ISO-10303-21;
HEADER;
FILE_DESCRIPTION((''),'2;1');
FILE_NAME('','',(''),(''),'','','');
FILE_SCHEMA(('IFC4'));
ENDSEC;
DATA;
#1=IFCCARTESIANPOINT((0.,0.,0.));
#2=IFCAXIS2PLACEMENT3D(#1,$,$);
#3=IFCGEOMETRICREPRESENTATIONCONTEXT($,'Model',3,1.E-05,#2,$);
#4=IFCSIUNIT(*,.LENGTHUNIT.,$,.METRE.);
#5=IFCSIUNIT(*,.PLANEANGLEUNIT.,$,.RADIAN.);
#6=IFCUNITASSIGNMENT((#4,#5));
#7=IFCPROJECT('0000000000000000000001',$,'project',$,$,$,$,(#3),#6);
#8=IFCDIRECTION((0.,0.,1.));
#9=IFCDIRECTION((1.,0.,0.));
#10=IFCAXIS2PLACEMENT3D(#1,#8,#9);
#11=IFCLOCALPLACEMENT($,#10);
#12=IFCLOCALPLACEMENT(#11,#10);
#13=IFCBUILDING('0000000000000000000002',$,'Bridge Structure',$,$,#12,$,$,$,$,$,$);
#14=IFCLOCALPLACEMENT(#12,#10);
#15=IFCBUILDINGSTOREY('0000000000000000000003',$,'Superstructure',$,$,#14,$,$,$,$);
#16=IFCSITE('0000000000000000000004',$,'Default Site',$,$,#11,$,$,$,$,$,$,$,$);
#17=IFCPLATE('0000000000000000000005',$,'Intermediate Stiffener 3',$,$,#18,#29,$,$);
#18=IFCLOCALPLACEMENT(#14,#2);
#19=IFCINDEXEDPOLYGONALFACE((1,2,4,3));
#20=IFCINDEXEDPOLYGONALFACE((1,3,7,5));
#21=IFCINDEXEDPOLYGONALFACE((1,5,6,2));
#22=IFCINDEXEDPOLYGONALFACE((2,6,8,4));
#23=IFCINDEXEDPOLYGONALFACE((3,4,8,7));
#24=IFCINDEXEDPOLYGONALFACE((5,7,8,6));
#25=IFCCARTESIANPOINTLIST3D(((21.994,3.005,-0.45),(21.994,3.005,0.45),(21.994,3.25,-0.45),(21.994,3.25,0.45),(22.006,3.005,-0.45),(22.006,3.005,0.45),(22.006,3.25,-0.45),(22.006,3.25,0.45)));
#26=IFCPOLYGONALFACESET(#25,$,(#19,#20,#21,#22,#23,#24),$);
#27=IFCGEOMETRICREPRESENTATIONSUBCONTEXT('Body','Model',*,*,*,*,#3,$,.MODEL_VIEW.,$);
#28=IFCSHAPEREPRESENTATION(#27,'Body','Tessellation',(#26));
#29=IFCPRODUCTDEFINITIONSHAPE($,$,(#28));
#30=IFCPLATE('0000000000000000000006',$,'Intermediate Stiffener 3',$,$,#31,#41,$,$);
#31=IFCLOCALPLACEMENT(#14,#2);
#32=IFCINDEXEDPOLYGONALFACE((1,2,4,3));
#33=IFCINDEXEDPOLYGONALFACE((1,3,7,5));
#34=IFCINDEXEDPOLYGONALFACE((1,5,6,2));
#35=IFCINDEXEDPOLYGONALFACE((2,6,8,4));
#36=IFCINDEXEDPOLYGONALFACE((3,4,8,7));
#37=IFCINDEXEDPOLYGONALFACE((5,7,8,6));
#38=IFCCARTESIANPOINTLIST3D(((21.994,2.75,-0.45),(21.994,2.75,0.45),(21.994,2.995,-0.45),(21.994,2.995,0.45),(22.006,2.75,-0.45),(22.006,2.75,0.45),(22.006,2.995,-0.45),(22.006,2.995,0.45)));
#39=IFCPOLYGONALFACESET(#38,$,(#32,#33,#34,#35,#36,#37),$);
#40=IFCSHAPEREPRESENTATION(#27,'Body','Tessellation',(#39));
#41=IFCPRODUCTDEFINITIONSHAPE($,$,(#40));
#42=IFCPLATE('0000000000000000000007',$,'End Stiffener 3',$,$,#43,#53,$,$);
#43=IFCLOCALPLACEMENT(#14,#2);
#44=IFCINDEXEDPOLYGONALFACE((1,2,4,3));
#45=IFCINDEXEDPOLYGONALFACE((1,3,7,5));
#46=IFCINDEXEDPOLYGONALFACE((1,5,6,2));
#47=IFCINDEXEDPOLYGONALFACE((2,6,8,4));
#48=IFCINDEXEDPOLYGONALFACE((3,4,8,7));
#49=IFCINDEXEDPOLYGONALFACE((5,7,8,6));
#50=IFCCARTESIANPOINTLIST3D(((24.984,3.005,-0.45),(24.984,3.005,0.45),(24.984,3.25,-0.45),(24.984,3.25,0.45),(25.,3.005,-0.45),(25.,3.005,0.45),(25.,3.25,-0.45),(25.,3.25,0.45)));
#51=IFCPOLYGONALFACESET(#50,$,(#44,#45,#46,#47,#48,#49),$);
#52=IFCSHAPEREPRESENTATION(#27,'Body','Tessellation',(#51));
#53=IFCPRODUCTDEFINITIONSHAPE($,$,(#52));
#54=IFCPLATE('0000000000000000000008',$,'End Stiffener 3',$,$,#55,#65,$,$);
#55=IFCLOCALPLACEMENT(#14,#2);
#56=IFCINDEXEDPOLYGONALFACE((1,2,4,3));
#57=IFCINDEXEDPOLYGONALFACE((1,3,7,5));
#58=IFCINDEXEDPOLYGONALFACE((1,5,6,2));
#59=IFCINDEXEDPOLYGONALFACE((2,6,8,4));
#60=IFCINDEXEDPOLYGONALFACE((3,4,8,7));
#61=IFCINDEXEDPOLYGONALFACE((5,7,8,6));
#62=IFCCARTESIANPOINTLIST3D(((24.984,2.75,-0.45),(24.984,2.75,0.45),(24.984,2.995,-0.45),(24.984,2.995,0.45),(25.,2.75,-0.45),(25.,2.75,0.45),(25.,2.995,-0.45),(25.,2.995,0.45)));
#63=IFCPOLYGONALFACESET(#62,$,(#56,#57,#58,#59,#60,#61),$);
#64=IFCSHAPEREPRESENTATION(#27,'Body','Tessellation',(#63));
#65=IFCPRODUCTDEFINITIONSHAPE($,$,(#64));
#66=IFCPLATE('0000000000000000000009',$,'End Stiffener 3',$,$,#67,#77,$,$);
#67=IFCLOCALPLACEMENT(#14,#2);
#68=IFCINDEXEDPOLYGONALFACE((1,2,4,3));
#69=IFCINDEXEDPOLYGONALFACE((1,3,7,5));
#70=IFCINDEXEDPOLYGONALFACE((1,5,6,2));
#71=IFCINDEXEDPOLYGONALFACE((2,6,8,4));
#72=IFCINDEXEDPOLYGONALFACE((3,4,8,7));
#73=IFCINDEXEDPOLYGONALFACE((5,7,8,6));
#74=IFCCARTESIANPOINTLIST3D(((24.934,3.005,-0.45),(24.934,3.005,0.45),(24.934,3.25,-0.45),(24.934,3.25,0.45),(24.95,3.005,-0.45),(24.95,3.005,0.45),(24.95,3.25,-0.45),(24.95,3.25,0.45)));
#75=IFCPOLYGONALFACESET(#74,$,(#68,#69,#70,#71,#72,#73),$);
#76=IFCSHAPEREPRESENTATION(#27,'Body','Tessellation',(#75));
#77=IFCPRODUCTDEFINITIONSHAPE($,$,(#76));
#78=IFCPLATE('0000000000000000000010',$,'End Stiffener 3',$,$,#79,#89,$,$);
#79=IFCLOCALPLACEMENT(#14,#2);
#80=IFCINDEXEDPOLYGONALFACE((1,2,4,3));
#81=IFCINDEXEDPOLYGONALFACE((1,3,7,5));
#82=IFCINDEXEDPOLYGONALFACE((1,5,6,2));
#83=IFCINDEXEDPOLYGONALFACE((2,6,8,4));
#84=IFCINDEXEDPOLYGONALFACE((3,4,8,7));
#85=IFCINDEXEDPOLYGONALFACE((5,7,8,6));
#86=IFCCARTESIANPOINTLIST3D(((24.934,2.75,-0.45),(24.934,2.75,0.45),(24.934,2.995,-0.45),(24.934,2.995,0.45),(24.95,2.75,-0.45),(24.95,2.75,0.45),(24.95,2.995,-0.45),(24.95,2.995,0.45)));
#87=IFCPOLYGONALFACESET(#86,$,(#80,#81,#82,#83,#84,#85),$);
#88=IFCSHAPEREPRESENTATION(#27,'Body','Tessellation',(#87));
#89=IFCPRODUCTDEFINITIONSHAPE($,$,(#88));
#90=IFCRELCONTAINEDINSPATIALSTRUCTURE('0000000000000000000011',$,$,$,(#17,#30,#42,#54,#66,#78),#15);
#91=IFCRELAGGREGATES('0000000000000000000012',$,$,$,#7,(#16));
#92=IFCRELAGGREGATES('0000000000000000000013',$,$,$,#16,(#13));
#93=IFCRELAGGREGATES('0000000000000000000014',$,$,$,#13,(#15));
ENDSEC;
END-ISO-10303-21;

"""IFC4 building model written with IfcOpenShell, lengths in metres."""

from ifc_helpers import new_model, si_unit, frame, origin, origin_with_axes, origin_2d_with_axis, place, context, subcontext, project, spatial, rectangle, extrude, element, save


model = new_model("IFC4")

# Units and contexts
model_context = context("Model", 3, precision=1e-05, world=origin())
body_context = subcontext(model_context, "Body", "Model", "MODEL_VIEW")
ifc_project = project(units=[si_unit("LENGTHUNIT", "METRE"), si_unit("PLANEANGLEUNIT", "RADIAN")], contexts=[model_context])

# Site, building, storey
site_placement = place(None, origin_with_axes())
site = spatial("IfcSite", under=ifc_project, at=site_placement, Name="Default Site")
building_placement = place(site_placement, origin_with_axes())
building = spatial("IfcBuilding", under=site, at=building_placement, Name="Bridge Structure")
storey_placement = place(building_placement, origin_with_axes())
storey = spatial("IfcBuildingStorey", under=building, at=storey_placement, Name="Superstructure")

# Plates
for number, where, z_axis, x_axis, name in (
    (1, (22.0, 3.1275, -0.45), (0.0, 0.0, 1.0), (1.0, 0.0, 0.0), "Intermediate Stiffener 3"),
    (2, (22.0, 2.8725, -0.45), (0.0, 0.0, 1.0), (1.0, 0.0, 0.0), "Intermediate Stiffener 3"),
):
    element("IfcPlate", number, at=place(storey_placement, frame(where, z_axis=z_axis, x_axis=x_axis)), inside=storey, Name=name, context=body_context, shape_type="SweptSolid", body=[
        extrude(rectangle(XDim=0.012, YDim=0.245, at=origin_2d_with_axis()), origin_with_axes(), (0.0, 0.0, 1.0), 0.9),
    ])
for number, where, z_axis, x_axis, name in (
    (3, (24.992, 3.1275, -0.45), (0.0, 0.0, 1.0), (1.0, 0.0, 0.0), "End Stiffener 3"),
    (4, (24.992, 2.8725, -0.45), (0.0, 0.0, 1.0), (1.0, 0.0, 0.0), "End Stiffener 3"),
    (5, (24.942, 3.1275, -0.45), (0.0, 0.0, 1.0), (1.0, 0.0, 0.0), "End Stiffener 3"),
    (6, (24.942, 2.8725, -0.45), (0.0, 0.0, 1.0), (1.0, 0.0, 0.0), "End Stiffener 3"),
):
    element("IfcPlate", number, at=place(storey_placement, frame(where, z_axis=z_axis, x_axis=x_axis)), inside=storey, Name=name, context=body_context, shape_type="SweptSolid", body=[
        extrude(rectangle(XDim=0.016, YDim=0.245, at=origin_2d_with_axis()), origin_with_axes(), (0.0, 0.0, 1.0), 0.9),
    ])

save(model, "model.ifc")
